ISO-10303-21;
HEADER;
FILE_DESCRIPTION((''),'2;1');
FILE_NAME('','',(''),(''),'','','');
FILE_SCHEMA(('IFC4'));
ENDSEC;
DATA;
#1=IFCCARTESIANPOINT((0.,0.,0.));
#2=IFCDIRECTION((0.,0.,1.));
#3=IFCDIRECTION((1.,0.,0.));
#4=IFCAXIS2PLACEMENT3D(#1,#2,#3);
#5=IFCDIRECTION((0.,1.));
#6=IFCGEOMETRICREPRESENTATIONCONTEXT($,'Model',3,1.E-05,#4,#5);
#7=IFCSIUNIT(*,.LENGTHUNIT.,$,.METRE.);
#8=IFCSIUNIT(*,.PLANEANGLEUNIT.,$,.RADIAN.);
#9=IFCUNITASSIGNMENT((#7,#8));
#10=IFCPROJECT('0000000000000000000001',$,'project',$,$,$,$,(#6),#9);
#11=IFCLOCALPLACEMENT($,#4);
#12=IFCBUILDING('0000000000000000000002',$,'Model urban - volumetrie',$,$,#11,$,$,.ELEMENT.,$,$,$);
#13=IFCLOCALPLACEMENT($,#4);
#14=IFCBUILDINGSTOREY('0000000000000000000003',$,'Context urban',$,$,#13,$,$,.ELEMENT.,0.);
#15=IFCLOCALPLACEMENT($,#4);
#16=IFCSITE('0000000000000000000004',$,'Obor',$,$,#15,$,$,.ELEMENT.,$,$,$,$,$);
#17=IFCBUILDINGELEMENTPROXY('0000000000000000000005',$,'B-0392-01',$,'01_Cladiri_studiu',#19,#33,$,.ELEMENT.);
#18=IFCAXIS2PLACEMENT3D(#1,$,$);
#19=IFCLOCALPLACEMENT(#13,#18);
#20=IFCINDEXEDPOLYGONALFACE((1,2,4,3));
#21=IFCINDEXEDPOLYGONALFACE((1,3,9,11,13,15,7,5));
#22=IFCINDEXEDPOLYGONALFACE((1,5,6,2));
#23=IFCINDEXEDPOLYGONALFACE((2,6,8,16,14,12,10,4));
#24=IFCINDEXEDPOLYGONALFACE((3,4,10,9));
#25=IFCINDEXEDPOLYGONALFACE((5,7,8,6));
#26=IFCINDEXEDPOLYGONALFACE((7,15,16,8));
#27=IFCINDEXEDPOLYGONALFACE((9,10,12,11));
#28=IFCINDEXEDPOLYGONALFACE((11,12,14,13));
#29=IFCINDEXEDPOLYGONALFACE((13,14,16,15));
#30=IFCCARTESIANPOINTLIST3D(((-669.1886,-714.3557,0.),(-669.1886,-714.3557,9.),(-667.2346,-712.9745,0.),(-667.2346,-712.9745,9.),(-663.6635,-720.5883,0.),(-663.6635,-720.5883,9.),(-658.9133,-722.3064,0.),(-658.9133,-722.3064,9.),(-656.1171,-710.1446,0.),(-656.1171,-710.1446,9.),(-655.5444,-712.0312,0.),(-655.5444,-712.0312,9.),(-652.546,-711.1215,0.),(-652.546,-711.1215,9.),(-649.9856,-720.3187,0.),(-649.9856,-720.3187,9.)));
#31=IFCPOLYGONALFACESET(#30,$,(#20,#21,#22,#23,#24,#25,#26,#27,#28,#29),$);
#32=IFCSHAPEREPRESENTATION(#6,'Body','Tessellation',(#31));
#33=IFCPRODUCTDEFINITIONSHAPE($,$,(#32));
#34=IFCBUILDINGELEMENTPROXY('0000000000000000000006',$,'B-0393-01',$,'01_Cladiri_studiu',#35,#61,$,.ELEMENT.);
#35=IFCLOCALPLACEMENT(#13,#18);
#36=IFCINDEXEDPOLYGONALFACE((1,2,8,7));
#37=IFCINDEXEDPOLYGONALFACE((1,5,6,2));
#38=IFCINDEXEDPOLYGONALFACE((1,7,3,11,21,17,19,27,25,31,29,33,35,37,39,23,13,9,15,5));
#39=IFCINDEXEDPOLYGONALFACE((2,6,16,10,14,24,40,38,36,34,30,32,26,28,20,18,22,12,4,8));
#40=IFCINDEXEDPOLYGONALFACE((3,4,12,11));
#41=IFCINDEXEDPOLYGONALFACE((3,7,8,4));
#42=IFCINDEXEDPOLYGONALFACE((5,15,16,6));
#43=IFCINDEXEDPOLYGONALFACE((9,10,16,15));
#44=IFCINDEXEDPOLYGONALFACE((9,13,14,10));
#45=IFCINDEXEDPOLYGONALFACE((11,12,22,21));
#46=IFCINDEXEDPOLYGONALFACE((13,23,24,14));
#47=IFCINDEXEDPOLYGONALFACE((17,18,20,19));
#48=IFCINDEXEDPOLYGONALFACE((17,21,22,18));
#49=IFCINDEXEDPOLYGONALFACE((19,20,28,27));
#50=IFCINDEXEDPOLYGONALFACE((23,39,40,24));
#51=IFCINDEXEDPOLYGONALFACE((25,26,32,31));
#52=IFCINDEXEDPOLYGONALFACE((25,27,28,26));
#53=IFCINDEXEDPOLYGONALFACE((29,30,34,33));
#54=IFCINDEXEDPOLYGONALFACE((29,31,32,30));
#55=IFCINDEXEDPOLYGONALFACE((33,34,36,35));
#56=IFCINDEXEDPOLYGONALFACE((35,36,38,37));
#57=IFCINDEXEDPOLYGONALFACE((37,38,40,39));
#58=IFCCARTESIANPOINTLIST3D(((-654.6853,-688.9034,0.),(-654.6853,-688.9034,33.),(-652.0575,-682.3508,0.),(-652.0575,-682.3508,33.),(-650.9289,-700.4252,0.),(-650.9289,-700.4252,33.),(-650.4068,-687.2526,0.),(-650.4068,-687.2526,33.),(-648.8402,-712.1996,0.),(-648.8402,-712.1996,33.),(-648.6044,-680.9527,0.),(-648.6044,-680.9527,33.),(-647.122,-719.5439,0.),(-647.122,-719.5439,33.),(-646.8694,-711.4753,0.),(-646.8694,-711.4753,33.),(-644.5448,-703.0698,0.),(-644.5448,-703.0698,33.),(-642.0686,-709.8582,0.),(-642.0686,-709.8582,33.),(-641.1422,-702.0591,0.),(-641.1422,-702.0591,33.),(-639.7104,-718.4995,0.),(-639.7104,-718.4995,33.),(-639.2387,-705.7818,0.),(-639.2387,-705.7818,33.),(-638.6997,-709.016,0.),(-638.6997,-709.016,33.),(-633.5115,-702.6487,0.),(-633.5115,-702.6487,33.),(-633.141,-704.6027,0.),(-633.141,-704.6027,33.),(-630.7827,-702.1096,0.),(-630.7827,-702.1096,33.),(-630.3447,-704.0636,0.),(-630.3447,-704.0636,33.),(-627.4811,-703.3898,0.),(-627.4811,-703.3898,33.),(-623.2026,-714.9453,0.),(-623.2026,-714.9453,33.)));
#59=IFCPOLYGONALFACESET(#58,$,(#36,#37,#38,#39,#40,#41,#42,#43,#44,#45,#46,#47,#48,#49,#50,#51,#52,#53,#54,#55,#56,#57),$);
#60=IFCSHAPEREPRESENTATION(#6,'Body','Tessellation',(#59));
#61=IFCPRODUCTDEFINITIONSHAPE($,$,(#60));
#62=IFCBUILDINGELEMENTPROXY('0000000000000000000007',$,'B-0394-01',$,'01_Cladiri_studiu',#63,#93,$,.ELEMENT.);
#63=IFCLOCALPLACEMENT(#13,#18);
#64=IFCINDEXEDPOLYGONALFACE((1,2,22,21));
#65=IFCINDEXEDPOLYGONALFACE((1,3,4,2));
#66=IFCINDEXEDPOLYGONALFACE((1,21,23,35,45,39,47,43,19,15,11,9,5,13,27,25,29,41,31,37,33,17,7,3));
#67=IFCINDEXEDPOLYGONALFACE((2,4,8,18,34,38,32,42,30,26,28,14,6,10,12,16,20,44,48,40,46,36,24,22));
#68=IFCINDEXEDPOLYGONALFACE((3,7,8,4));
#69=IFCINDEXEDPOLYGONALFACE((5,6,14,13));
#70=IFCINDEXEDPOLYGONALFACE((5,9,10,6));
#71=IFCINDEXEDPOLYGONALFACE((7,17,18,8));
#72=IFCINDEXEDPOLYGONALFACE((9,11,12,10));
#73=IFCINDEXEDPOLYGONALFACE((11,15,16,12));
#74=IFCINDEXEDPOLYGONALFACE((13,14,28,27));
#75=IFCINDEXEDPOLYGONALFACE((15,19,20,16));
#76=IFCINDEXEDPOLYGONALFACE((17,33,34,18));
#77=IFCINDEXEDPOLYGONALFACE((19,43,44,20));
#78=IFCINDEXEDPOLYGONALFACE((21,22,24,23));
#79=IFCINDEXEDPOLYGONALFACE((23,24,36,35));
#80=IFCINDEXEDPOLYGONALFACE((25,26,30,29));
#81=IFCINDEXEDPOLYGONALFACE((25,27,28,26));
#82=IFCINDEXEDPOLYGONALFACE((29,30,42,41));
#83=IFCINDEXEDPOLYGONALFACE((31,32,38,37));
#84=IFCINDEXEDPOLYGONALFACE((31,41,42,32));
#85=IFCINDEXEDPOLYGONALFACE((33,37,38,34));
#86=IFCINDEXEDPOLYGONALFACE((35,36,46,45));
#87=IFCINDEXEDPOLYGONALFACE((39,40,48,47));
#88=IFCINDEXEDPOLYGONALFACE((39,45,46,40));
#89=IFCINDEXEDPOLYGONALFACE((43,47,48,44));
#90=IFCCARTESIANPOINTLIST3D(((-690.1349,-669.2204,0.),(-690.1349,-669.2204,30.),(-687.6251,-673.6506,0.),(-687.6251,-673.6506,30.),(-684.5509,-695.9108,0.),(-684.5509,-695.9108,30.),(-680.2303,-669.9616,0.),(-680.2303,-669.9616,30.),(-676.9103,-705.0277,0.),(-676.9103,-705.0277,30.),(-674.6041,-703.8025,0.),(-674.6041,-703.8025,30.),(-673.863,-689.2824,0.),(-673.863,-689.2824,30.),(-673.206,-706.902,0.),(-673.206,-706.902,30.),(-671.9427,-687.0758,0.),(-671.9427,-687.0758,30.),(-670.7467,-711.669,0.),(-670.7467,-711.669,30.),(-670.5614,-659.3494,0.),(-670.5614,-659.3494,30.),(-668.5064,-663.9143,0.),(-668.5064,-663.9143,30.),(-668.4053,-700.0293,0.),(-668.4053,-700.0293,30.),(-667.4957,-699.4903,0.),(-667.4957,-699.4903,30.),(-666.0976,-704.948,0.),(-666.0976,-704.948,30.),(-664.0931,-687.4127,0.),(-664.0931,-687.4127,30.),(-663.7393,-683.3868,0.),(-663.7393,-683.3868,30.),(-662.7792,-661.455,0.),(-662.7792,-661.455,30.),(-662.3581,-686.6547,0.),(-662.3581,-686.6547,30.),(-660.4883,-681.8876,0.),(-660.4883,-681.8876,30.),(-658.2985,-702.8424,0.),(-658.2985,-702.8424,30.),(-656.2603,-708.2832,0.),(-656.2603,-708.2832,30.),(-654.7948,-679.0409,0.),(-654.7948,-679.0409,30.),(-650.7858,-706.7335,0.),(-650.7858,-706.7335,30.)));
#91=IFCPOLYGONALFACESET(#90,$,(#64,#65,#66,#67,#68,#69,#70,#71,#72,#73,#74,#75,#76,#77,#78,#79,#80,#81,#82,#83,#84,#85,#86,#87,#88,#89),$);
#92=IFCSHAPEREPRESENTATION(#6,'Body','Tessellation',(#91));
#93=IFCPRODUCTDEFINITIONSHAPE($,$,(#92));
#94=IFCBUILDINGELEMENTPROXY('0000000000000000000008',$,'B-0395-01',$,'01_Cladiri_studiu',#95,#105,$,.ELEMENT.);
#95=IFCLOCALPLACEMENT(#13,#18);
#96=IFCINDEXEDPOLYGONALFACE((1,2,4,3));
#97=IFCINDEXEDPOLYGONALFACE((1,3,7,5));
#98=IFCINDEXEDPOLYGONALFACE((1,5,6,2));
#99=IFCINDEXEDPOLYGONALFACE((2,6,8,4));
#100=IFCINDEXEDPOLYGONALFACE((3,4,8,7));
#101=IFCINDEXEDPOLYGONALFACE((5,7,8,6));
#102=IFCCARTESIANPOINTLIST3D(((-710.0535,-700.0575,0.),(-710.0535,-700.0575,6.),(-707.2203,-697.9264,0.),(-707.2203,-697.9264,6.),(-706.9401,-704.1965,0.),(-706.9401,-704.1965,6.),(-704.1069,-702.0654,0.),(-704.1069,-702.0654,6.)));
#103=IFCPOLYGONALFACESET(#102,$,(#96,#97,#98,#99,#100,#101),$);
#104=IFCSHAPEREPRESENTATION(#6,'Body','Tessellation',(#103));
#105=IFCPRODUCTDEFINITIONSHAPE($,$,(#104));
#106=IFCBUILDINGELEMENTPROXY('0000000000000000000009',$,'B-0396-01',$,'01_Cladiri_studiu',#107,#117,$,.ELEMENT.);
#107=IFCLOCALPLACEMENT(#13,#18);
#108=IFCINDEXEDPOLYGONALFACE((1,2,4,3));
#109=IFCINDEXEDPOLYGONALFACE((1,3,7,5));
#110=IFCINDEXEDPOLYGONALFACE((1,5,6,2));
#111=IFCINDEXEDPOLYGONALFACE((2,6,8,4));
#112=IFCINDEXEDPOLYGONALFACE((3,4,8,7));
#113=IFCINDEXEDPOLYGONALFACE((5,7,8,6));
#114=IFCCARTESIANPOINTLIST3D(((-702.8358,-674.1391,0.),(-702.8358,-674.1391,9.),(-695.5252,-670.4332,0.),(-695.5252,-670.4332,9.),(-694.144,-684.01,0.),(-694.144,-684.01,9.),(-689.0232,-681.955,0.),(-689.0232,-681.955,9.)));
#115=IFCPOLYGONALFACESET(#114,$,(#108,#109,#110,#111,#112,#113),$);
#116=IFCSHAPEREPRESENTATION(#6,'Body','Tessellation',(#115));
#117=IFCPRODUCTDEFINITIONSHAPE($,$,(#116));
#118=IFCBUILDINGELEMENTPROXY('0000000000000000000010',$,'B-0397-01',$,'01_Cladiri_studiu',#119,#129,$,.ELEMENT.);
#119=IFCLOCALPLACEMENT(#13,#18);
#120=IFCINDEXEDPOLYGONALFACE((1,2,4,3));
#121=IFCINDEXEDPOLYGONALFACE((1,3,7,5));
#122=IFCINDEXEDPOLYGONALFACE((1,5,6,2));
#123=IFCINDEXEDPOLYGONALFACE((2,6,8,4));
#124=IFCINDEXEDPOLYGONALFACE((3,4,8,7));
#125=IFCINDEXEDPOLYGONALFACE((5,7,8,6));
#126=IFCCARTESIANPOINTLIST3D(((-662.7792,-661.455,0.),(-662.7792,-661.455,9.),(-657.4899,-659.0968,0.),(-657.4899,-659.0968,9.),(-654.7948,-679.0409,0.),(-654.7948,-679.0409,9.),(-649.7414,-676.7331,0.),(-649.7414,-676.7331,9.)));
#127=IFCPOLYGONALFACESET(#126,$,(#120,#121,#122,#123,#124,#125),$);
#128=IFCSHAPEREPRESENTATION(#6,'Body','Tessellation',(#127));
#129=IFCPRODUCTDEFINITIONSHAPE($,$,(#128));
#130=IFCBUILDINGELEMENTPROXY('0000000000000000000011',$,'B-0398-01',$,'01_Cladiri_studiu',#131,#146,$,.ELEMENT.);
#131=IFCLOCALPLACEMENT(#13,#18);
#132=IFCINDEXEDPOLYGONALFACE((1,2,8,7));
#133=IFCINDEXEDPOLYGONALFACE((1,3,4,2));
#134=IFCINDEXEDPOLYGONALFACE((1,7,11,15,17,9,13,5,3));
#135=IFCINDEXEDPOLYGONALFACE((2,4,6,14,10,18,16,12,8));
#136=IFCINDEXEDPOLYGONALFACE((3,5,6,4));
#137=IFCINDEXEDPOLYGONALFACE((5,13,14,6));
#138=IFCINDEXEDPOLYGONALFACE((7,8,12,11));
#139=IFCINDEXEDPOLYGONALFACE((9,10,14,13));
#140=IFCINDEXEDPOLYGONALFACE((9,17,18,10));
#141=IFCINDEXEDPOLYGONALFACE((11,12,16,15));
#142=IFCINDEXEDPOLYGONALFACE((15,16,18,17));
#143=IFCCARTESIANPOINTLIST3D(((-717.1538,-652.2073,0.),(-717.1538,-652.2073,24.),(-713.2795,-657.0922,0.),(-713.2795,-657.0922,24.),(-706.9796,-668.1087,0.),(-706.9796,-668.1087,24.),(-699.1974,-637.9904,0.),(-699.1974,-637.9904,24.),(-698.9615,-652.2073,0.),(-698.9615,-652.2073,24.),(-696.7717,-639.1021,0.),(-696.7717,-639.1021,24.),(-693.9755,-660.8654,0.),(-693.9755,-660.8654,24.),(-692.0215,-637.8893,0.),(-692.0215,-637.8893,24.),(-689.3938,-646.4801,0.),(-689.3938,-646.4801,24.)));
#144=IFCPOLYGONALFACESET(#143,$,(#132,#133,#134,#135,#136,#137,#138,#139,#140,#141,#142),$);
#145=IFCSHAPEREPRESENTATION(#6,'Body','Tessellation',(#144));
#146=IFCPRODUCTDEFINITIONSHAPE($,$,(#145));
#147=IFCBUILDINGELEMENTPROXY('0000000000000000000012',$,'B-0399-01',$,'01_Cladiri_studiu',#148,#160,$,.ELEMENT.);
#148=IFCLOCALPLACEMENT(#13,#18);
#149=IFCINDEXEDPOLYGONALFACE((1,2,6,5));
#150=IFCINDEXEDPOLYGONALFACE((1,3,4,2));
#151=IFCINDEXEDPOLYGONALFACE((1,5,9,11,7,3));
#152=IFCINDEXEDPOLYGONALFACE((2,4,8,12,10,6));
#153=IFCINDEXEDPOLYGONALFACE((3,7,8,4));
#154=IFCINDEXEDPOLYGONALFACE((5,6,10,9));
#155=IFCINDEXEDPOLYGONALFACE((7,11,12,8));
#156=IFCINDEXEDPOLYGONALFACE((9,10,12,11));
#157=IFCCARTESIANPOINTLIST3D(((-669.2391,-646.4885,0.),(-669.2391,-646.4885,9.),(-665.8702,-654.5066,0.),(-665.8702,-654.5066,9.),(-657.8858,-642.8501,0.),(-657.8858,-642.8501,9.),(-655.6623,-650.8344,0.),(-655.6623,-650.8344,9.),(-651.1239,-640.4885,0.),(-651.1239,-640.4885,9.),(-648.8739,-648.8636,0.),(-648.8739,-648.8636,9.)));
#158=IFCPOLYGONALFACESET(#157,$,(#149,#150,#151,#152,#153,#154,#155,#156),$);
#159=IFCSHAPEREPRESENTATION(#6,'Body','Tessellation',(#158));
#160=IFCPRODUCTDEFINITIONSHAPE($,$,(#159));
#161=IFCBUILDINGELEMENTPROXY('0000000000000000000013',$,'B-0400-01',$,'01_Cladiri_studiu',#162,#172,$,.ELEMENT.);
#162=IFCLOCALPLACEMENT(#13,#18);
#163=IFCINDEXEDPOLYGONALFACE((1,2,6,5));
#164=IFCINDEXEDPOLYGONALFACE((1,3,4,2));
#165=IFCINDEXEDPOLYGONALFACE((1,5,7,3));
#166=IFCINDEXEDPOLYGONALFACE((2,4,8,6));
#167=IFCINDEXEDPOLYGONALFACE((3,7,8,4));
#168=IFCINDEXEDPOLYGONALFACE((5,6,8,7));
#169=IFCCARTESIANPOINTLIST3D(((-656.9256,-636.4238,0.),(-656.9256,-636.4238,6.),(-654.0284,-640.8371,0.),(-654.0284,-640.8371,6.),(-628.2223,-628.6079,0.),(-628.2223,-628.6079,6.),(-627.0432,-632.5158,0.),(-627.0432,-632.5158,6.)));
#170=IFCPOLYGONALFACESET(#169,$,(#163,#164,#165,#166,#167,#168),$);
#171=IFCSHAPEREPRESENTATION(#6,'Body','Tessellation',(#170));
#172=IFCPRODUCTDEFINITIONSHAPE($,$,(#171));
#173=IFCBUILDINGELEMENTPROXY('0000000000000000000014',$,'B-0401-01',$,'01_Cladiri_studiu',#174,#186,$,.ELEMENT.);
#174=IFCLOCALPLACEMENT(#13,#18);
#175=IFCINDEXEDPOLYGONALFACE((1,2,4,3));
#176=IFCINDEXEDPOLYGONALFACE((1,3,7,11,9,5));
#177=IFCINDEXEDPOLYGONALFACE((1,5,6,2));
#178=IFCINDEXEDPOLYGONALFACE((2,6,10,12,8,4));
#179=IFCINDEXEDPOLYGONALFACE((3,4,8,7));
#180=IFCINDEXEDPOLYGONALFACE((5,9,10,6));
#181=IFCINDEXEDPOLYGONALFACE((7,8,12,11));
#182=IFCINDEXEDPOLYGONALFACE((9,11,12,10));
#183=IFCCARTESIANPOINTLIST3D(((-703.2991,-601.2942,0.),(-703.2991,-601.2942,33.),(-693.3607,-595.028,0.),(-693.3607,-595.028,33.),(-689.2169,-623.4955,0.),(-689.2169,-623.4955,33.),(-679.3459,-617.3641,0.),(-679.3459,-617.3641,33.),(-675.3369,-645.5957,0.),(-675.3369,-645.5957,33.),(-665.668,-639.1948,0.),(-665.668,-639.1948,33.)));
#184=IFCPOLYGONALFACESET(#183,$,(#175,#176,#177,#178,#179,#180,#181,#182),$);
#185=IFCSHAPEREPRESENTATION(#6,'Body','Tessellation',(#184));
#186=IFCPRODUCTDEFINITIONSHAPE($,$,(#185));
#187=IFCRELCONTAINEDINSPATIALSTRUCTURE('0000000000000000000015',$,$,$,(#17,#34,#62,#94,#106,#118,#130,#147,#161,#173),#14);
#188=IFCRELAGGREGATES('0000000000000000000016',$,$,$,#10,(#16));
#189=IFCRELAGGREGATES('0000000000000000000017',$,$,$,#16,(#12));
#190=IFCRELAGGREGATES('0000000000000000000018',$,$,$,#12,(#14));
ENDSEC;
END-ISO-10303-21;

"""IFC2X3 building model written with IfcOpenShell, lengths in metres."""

from ifc_helpers import new_model, si_unit, direction, origin_with_axes, place, context, project, spatial, polyline, outline, extrude, element, save


model = new_model("IFC2X3")

# Units and contexts
model_context = context("Model", 3, precision=1e-05, world=origin_with_axes(), true_north=direction((0.0, 1.0)))
ifc_project = project(units=[si_unit("LENGTHUNIT", "METRE"), si_unit("PLANEANGLEUNIT", "RADIAN")], contexts=[model_context])

# Site, building, storey
site_placement = place(None, origin_with_axes())
site = spatial("IfcSite", under=ifc_project, at=site_placement, Name="Obor", CompositionType="ELEMENT")
building_placement = place(None, origin_with_axes())
building = spatial("IfcBuilding", under=site, at=building_placement, Name="Model urban - volumetrie", CompositionType="ELEMENT")
storey_placement = place(None, origin_with_axes())
storey = spatial("IfcBuildingStorey", under=building, at=storey_placement, Name="Context urban", CompositionType="ELEMENT", Elevation=0.0)

# Building element proxies
proxy_1_placement = place(None, origin_with_axes())
element("IfcBuildingElementProxy", 1, at=proxy_1_placement, inside=storey, Name="B-0392-01", ObjectType="01_Cladiri_studiu", CompositionType="ELEMENT", context=model_context, shape_type="SweptSolid", body=[
    extrude(outline(polyline([(-658.9133, -722.3064), (-649.9856, -720.3187), (-652.546, -711.1215), (-655.5444, -712.0312), (-656.1171, -710.1446), (-667.2346, -712.9745), (-669.1886, -714.3557), (-663.6635, -720.5883), (-658.9133, -722.3064)])), origin_with_axes(), (0.0, 0.0, 1.0), 9.0),
])
proxy_2_placement = place(None, origin_with_axes())
element("IfcBuildingElementProxy", 2, at=proxy_2_placement, inside=storey, Name="B-0393-01", ObjectType="01_Cladiri_studiu", CompositionType="ELEMENT", context=model_context, shape_type="SweptSolid", body=[
    extrude(outline(polyline([(-644.5448, -703.0698), (-641.1422, -702.0591), (-648.6044, -680.9527), (-652.0575, -682.3508), (-650.4068, -687.2526), (-654.6853, -688.9034), (-650.9289, -700.4252), (-646.8694, -711.4753), (-648.8402, -712.1996), (-647.122, -719.5439), (-639.7104, -718.4995), (-623.2026, -714.9453), (-627.4811, -703.3898), (-630.3447, -704.0636), (-630.7827, -702.1096), (-633.5115, -702.6487), (-633.141, -704.6027), (-639.2387, -705.7818), (-638.6997, -709.016), (-642.0686, -709.8582), (-644.5448, -703.0698)])), origin_with_axes(), (0.0, 0.0, 1.0), 33.0),
])
proxy_3_placement = place(None, origin_with_axes())
element("IfcBuildingElementProxy", 3, at=proxy_3_placement, inside=storey, Name="B-0394-01", ObjectType="01_Cladiri_studiu", CompositionType="ELEMENT", context=model_context, shape_type="SweptSolid", body=[
    extrude(outline(polyline([(-662.3581, -686.6547), (-664.0931, -687.4127), (-658.2985, -702.8424), (-666.0976, -704.948), (-668.4053, -700.0293), (-667.4957, -699.4903), (-673.863, -689.2824), (-684.5509, -695.9108), (-676.9103, -705.0277), (-674.6041, -703.8025), (-673.206, -706.902), (-670.7467, -711.669), (-656.2603, -708.2832), (-650.7858, -706.7335), (-660.4883, -681.8876), (-654.7948, -679.0409), (-662.7792, -661.455), (-668.5064, -663.9143), (-670.5614, -659.3494), (-690.1349, -669.2204), (-687.6251, -673.6506), (-680.2303, -669.9616), (-671.9427, -687.0758), (-663.7393, -683.3868), (-662.3581, -686.6547)])), origin_with_axes(), (0.0, 0.0, 1.0), 30.0),
])
proxy_4_placement = place(None, origin_with_axes())
element("IfcBuildingElementProxy", 4, at=proxy_4_placement, inside=storey, Name="B-0395-01", ObjectType="01_Cladiri_studiu", CompositionType="ELEMENT", context=model_context, shape_type="SweptSolid", body=[
    extrude(outline(polyline([(-706.9401, -704.1965), (-704.1069, -702.0654), (-707.2203, -697.9264), (-710.0535, -700.0575), (-706.9401, -704.1965)])), origin_with_axes(), (0.0, 0.0, 1.0), 6.0),
])
proxy_5_placement = place(None, origin_with_axes())
element("IfcBuildingElementProxy", 5, at=proxy_5_placement, inside=storey, Name="B-0396-01", ObjectType="01_Cladiri_studiu", CompositionType="ELEMENT", context=model_context, shape_type="SweptSolid", body=[
    extrude(outline(polyline([(-689.0232, -681.955), (-695.5252, -670.4332), (-702.8358, -674.1391), (-694.144, -684.01), (-689.0232, -681.955)])), origin_with_axes(), (0.0, 0.0, 1.0), 9.0),
])
proxy_6_placement = place(None, origin_with_axes())
element("IfcBuildingElementProxy", 6, at=proxy_6_placement, inside=storey, Name="B-0397-01", ObjectType="01_Cladiri_studiu", CompositionType="ELEMENT", context=model_context, shape_type="SweptSolid", body=[
    extrude(outline(polyline([(-649.7414, -676.7331), (-657.4899, -659.0968), (-662.7792, -661.455), (-654.7948, -679.0409), (-649.7414, -676.7331)])), origin_with_axes(), (0.0, 0.0, 1.0), 9.0),
])
proxy_7_placement = place(None, origin_with_axes())
element("IfcBuildingElementProxy", 7, at=proxy_7_placement, inside=storey, Name="B-0398-01", ObjectType="01_Cladiri_studiu", CompositionType="ELEMENT", context=model_context, shape_type="SweptSolid", body=[
    extrude(outline(polyline([(-692.0215, -637.8893), (-696.7717, -639.1021), (-699.1974, -637.9904), (-717.1538, -652.2073), (-713.2795, -657.0922), (-706.9796, -668.1087), (-693.9755, -660.8654), (-698.9615, -652.2073), (-689.3938, -646.4801), (-692.0215, -637.8893)])), origin_with_axes(), (0.0, 0.0, 1.0), 24.0),
])
proxy_8_placement = place(None, origin_with_axes())
element("IfcBuildingElementProxy", 8, at=proxy_8_placement, inside=storey, Name="B-0399-01", ObjectType="01_Cladiri_studiu", CompositionType="ELEMENT", context=model_context, shape_type="SweptSolid", body=[
    extrude(outline(polyline([(-669.2391, -646.4885), (-665.8702, -654.5066), (-655.6623, -650.8344), (-648.8739, -648.8636), (-651.1239, -640.4885), (-657.8858, -642.8501), (-669.2391, -646.4885)])), origin_with_axes(), (0.0, 0.0, 1.0), 9.0),
])
proxy_9_placement = place(None, origin_with_axes())
element("IfcBuildingElementProxy", 9, at=proxy_9_placement, inside=storey, Name="B-0400-01", ObjectType="01_Cladiri_studiu", CompositionType="ELEMENT", context=model_context, shape_type="SweptSolid", body=[
    extrude(outline(polyline([(-628.2223, -628.6079), (-656.9256, -636.4238), (-654.0284, -640.8371), (-627.0432, -632.5158), (-628.2223, -628.6079)])), origin_with_axes(), (0.0, 0.0, 1.0), 6.0),
])
proxy_10_placement = place(None, origin_with_axes())
element("IfcBuildingElementProxy", 10, at=proxy_10_placement, inside=storey, Name="B-0401-01", ObjectType="01_Cladiri_studiu", CompositionType="ELEMENT", context=model_context, shape_type="SweptSolid", body=[
    extrude(outline(polyline([(-679.3459, -617.3641), (-693.3607, -595.028), (-703.2991, -601.2942), (-689.2169, -623.4955), (-675.3369, -645.5957), (-665.668, -639.1948), (-679.3459, -617.3641)])), origin_with_axes(), (0.0, 0.0, 1.0), 33.0),
])

save(model, "model.ifc")
